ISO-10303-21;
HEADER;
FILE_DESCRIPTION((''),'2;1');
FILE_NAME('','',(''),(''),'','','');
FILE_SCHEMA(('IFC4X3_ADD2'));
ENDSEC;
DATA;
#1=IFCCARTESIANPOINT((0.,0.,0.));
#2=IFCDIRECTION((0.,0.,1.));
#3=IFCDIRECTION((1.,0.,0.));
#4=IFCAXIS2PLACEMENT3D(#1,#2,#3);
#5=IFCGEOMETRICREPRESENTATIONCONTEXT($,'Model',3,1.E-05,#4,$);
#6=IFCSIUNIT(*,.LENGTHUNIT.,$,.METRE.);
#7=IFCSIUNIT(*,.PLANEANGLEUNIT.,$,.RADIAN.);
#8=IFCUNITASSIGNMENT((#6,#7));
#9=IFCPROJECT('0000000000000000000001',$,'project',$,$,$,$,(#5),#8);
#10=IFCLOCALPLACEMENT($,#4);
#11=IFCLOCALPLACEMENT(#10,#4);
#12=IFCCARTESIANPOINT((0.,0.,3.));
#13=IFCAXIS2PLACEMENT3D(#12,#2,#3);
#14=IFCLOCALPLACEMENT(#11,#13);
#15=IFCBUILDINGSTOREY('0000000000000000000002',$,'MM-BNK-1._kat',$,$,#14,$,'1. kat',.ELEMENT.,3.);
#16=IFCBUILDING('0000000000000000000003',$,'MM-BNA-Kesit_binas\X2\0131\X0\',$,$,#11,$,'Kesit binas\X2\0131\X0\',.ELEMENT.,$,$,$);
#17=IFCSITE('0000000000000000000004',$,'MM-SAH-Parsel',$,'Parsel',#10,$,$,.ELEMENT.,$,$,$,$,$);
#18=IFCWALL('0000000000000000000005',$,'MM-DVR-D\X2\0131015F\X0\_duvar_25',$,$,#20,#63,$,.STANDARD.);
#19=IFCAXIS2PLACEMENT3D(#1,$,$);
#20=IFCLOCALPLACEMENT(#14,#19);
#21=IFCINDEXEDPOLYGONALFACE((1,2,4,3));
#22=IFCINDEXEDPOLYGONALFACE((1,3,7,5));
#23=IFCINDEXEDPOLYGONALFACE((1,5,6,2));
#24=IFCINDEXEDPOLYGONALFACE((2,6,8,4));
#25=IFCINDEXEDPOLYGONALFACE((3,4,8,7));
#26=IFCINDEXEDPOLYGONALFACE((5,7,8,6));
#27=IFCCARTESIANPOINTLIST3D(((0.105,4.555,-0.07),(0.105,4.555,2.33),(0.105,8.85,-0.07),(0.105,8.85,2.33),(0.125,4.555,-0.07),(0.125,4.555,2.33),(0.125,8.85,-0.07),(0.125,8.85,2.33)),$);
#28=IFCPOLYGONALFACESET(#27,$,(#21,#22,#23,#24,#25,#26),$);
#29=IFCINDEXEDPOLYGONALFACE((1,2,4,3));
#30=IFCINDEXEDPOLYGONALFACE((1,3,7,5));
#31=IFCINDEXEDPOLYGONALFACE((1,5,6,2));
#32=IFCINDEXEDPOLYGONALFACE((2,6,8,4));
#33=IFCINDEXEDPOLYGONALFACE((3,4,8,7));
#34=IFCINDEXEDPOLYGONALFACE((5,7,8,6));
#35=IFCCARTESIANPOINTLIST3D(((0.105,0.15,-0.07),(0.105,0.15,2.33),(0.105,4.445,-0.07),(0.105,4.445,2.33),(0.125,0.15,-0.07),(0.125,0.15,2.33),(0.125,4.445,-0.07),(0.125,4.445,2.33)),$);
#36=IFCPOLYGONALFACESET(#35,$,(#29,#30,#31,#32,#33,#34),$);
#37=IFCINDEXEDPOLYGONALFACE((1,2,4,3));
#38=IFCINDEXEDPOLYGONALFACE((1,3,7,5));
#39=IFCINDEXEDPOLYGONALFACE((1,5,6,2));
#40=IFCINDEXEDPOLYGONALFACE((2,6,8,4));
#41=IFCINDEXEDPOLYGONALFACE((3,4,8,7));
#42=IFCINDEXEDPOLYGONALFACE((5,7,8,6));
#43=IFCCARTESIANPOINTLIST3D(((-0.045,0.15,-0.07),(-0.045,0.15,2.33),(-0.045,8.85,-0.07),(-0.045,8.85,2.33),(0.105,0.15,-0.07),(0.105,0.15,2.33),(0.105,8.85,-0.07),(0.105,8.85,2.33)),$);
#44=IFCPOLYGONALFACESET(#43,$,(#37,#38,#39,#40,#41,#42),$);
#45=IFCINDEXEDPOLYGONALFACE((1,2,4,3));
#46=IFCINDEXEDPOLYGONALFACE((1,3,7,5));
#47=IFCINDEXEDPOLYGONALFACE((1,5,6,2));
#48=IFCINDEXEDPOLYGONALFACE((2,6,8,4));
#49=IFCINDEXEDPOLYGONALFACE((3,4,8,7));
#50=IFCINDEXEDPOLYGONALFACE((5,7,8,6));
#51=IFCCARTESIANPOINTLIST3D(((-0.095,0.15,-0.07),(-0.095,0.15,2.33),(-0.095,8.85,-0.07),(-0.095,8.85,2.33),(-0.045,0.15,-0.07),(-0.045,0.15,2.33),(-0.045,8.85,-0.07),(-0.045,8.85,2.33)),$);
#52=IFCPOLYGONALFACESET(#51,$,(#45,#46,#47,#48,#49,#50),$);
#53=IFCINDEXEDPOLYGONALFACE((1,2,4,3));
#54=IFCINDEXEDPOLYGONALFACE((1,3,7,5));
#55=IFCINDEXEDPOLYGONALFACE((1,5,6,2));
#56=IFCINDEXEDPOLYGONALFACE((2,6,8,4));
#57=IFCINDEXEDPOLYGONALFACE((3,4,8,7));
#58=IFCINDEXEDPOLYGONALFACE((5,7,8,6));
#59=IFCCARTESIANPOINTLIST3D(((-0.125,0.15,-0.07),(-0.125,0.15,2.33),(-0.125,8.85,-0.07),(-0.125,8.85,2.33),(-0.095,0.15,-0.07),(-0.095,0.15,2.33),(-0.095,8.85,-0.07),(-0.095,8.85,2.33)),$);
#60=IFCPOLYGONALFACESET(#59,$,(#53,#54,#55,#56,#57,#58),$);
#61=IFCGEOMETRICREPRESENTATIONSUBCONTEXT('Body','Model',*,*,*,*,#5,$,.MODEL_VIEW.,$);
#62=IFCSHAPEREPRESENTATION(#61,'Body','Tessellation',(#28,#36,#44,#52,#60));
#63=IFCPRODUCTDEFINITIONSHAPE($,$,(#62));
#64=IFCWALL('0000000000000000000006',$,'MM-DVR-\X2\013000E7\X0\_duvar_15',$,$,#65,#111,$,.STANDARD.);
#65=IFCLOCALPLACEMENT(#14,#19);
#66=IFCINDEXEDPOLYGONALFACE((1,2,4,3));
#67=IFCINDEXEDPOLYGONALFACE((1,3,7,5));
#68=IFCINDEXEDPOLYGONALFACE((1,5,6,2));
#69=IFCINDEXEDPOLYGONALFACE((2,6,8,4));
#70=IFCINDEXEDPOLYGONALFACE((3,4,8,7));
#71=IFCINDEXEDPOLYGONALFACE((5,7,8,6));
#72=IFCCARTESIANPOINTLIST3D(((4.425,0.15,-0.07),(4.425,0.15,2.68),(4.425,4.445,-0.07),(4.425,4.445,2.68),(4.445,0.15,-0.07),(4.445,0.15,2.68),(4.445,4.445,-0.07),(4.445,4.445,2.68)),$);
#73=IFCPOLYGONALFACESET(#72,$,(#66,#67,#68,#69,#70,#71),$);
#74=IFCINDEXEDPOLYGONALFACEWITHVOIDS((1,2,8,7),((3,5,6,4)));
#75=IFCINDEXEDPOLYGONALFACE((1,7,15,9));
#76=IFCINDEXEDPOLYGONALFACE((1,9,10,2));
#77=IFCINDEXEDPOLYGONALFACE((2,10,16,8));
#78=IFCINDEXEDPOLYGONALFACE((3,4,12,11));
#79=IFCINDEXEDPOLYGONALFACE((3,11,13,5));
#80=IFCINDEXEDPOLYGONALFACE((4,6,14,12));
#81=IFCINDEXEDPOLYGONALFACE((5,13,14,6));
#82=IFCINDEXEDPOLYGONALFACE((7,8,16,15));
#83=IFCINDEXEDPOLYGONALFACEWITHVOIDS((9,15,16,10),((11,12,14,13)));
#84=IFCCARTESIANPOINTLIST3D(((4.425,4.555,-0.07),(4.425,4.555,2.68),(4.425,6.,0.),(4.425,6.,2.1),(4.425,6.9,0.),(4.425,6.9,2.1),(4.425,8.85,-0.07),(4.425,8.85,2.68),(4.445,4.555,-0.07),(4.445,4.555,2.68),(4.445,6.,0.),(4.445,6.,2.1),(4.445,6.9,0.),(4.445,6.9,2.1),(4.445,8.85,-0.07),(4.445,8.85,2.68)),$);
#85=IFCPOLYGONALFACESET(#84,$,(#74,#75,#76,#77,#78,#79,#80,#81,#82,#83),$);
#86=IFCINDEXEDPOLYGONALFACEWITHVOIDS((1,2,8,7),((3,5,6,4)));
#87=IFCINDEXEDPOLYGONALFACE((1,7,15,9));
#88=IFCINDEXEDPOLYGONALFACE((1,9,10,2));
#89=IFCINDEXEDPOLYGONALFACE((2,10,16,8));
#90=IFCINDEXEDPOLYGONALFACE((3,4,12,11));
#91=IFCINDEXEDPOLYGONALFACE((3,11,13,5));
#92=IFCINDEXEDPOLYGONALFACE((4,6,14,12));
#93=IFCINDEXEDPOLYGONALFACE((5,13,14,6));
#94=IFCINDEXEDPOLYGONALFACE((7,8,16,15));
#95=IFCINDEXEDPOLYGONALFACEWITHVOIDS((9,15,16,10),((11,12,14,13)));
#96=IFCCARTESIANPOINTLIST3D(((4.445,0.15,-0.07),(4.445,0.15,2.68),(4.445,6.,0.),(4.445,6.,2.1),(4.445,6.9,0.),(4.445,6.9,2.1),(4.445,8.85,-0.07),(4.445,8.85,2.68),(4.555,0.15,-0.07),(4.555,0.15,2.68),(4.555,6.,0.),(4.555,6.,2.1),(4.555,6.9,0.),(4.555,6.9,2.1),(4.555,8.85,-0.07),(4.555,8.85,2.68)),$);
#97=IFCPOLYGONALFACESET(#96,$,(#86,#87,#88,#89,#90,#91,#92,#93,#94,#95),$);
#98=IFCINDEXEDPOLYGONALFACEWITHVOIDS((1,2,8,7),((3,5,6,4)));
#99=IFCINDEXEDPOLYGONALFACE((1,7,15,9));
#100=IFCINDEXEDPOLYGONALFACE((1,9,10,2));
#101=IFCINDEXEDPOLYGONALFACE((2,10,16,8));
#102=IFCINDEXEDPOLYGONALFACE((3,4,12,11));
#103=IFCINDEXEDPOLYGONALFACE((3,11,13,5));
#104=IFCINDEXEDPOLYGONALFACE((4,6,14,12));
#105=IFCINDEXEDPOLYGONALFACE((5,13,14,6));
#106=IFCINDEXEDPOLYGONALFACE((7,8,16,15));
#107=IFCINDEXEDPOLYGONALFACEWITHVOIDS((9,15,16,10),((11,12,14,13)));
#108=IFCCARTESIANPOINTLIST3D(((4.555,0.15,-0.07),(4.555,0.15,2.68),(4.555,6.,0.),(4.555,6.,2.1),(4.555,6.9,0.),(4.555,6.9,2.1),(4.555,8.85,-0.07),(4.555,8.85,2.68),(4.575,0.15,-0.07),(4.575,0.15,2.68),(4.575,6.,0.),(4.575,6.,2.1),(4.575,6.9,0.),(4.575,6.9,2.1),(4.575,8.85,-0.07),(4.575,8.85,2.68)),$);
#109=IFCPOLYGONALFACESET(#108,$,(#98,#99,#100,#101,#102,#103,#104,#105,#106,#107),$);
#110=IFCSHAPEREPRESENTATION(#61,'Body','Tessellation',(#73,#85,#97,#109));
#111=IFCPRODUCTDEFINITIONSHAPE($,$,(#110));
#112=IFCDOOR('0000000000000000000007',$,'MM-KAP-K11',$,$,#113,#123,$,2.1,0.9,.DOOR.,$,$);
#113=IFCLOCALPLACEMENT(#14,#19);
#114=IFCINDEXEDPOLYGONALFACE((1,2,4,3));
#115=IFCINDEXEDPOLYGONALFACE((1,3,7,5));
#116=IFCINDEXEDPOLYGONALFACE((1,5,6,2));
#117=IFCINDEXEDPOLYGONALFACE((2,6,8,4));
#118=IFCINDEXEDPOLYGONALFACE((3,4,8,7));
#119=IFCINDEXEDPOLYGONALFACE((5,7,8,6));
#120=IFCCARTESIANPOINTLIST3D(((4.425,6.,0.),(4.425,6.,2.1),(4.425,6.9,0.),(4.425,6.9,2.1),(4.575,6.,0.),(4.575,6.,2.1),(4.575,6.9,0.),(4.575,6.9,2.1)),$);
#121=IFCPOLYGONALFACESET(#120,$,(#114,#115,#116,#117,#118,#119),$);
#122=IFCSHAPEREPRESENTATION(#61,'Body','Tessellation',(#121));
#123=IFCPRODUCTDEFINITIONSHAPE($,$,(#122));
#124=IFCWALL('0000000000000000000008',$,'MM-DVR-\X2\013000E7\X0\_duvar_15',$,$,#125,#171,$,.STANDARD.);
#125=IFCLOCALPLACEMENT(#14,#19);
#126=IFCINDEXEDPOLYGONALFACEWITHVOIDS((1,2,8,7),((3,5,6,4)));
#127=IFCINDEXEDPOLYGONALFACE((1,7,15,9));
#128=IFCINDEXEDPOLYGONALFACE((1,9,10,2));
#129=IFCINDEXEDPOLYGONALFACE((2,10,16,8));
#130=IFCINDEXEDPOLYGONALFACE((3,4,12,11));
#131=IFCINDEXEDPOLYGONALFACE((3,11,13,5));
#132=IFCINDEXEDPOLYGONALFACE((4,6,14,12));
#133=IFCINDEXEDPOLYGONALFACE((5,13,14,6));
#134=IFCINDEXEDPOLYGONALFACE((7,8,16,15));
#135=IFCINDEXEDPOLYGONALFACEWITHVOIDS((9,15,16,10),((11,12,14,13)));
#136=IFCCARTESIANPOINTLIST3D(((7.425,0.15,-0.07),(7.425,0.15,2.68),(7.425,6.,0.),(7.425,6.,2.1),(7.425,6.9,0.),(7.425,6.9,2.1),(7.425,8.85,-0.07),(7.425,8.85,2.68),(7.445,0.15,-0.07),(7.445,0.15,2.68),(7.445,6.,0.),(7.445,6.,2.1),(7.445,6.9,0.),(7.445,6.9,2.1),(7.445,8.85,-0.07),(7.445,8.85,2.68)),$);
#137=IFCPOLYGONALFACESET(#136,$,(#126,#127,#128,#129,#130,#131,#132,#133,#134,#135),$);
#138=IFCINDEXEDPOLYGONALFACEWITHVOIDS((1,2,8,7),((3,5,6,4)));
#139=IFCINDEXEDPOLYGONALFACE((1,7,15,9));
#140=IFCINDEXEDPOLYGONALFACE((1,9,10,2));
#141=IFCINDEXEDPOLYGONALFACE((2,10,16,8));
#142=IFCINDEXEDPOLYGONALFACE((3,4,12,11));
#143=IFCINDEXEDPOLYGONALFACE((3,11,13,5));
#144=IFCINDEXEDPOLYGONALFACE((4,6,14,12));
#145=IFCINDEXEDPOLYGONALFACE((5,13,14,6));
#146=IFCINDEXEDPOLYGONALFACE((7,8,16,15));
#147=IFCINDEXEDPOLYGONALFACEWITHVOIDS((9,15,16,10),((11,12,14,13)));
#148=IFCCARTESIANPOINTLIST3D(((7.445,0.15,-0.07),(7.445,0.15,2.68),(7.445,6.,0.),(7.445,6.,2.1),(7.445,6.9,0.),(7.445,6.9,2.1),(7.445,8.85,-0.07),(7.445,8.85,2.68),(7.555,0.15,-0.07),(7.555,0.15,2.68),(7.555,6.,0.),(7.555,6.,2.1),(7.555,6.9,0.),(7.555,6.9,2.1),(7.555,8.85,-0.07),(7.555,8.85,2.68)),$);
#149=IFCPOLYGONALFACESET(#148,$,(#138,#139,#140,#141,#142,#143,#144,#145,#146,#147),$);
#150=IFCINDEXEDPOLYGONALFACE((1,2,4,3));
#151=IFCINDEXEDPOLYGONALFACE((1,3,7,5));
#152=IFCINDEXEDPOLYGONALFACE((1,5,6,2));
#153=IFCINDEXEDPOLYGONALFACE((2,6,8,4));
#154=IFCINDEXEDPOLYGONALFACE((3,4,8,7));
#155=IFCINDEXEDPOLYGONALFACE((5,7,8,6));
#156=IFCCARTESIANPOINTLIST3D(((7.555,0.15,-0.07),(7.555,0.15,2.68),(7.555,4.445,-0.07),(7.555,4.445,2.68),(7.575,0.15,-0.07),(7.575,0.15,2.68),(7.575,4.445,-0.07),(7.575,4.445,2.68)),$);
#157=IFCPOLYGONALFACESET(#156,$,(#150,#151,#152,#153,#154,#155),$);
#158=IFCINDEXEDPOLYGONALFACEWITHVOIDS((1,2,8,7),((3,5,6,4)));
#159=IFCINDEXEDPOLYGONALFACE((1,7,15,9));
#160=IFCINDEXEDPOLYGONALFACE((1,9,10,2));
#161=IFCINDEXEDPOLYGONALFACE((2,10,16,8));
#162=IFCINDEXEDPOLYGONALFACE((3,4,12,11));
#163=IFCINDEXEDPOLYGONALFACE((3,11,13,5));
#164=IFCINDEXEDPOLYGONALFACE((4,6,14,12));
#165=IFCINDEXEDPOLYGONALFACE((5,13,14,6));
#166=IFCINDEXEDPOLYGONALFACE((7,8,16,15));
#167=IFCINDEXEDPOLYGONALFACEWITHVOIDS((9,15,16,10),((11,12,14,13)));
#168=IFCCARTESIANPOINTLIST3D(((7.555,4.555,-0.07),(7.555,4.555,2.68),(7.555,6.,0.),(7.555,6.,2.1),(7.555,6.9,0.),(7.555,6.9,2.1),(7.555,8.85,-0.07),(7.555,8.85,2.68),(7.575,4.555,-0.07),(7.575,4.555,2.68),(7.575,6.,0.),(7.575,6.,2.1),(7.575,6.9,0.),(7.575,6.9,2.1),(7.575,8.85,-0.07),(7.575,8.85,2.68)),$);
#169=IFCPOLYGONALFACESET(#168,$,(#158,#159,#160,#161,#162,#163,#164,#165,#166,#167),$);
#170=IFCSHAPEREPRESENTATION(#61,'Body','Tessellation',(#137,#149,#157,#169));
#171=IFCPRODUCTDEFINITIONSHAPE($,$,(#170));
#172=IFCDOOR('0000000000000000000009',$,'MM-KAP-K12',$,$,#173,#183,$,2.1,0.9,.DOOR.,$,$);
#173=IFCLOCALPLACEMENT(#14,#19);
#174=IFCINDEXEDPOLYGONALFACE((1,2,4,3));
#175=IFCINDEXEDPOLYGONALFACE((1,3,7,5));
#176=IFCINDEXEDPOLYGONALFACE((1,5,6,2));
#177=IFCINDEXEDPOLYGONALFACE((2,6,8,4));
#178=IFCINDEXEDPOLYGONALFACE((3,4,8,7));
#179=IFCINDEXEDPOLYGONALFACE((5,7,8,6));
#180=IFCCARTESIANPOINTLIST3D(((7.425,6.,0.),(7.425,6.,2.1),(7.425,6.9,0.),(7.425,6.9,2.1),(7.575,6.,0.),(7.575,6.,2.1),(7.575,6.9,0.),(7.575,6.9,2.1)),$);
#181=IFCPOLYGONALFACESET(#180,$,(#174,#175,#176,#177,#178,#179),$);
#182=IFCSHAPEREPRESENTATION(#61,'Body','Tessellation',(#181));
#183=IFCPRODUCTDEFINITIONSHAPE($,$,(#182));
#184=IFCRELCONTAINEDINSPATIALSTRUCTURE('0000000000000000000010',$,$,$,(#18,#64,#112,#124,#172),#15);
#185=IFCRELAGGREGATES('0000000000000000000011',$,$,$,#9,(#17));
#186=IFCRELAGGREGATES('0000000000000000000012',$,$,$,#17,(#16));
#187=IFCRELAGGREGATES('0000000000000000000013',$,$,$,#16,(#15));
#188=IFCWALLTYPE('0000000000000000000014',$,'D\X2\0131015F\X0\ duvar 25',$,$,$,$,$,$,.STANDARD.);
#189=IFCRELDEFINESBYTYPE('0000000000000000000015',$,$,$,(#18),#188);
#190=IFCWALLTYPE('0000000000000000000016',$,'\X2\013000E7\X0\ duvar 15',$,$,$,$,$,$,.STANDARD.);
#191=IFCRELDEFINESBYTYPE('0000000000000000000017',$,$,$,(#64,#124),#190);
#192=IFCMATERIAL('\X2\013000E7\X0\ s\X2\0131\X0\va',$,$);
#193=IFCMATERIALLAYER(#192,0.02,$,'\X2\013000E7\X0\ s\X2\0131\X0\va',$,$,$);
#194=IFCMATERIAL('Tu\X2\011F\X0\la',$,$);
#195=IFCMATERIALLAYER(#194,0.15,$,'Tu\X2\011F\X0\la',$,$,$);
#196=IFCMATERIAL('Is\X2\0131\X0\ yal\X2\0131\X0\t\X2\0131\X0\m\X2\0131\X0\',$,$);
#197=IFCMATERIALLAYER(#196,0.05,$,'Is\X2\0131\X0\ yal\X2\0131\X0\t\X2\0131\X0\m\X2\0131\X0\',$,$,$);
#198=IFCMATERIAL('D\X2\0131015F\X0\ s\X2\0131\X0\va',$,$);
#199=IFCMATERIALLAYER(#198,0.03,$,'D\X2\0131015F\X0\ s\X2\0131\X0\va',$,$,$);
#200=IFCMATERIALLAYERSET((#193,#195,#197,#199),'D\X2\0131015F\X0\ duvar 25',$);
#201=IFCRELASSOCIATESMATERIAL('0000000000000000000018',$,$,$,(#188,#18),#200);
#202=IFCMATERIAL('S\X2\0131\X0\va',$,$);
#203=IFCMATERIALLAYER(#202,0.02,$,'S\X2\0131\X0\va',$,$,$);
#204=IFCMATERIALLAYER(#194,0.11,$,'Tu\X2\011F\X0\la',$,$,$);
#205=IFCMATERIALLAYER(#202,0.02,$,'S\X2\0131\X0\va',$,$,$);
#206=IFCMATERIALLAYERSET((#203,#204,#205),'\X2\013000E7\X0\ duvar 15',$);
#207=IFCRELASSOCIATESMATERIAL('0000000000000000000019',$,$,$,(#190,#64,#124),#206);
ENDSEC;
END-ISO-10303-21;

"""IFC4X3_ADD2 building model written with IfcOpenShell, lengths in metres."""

from ifc_helpers import new_model, si_unit, frame, origin, origin_with_axes, place, context, subcontext, project, spatial, polyline, outline, extrude, material, layer, layer_set, type_object, element, fill, save


model = new_model("IFC4X3_ADD2")

# Units and contexts
model_context = context("Model", 3, precision=1e-05, world=origin_with_axes())
body_context = subcontext(model_context, "Body", "Model", "MODEL_VIEW")
ifc_project = project(units=[si_unit("LENGTHUNIT", "METRE"), si_unit("PLANEANGLEUNIT", "RADIAN")], contexts=[model_context])

# Site, building, storey
site_placement = place(None, origin_with_axes())
site = spatial("IfcSite", under=ifc_project, at=site_placement, Name="MM-SAH-Parsel", ObjectType="Parsel", CompositionType="ELEMENT")
building_placement = place(site_placement, origin_with_axes())
building = spatial("IfcBuilding", under=site, at=building_placement, Name="MM-BNA-Kesit_binası", LongName="Kesit binası", CompositionType="ELEMENT")
storey_placement = place(building_placement, frame((0.0, 0.0, 3.0), z_axis=(0.0, 0.0, 1.0), x_axis=(1.0, 0.0, 0.0)))
storey = spatial("IfcBuildingStorey", under=building, at=storey_placement, Name="MM-BNK-1._kat", LongName="1. kat", CompositionType="ELEMENT", Elevation=3.0)

# Shared definitions
ifc_material_1 = material(Name="İç sıva")
ifc_layer_1 = layer(ifc_material_1, 0.02, Name="İç sıva")
ifc_material_2 = material(Name="Tuğla")
ifc_layer_2 = layer(ifc_material_2, 0.15, Name="Tuğla")
ifc_material_3 = material(Name="Isı yalıtımı")
ifc_layer_3 = layer(ifc_material_3, 0.05, Name="Isı yalıtımı")
ifc_material_4 = material(Name="Dış sıva")
ifc_layer_4 = layer(ifc_material_4, 0.03, Name="Dış sıva")
ifc_layer_set_1 = layer_set([ifc_layer_1, ifc_layer_2, ifc_layer_3, ifc_layer_4], Name="Dış duvar 25")
wall_type_1 = type_object("IfcWallType", Name="Dış duvar 25", PredefinedType="STANDARD", material=ifc_layer_set_1)

# Wall
wall_1_placement = place(storey_placement, origin_with_axes())
element("IfcWall", 1, at=wall_1_placement, inside=storey, type_object=wall_type_1, material=ifc_layer_set_1, Name="MM-DVR-Dış_duvar_25", PredefinedType="STANDARD", context=body_context, shape_type="SweptSolid", body=[
    extrude(outline(polyline([(0.105, 8.85), (0.105, 4.555), (0.125, 4.555), (0.125, 8.85), (0.105, 8.85)])), frame((0.0, 0.0, -0.07)), (0.0, 0.0, 1.0), 2.4),
    extrude(outline(polyline([(0.105, 4.445), (0.105, 0.15), (0.125, 0.15), (0.125, 4.445), (0.105, 4.445)])), frame((0.0, 0.0, -0.07)), (0.0, 0.0, 1.0), 2.4),
    extrude(outline(polyline([(-0.045, 8.85), (-0.045, 0.15), (0.105, 0.15), (0.105, 8.85), (-0.045, 8.85)])), frame((0.0, 0.0, -0.07)), (0.0, 0.0, 1.0), 2.4),
    extrude(outline(polyline([(-0.095, 8.85), (-0.095, 0.15), (-0.045, 0.15), (-0.045, 8.85), (-0.095, 8.85)])), frame((0.0, 0.0, -0.07)), (0.0, 0.0, 1.0), 2.4),
    extrude(outline(polyline([(-0.125, 8.85), (-0.125, 0.15), (-0.095, 0.15), (-0.095, 8.85), (-0.125, 8.85)])), frame((0.0, 0.0, -0.07)), (0.0, 0.0, 1.0), 2.4),
])

# Walls, openings, doors
ifc_material_5 = material(Name="Sıva")
ifc_layer_5 = layer(ifc_material_5, 0.02, Name="Sıva")
ifc_layer_6 = layer(ifc_material_2, 0.11, Name="Tuğla")
ifc_layer_7 = layer(ifc_material_5, 0.02, Name="Sıva")
ifc_layer_set_2 = layer_set([ifc_layer_5, ifc_layer_6, ifc_layer_7], Name="İç duvar 15")
wall_type_2 = type_object("IfcWallType", Name="İç duvar 15", PredefinedType="STANDARD", material=ifc_layer_set_2)
wall_2_placement = place(storey_placement, origin_with_axes())
wall_2 = element("IfcWall", 2, at=wall_2_placement, inside=storey, type_object=wall_type_2, material=ifc_layer_set_2, Name="MM-DVR-İç_duvar_15", PredefinedType="STANDARD", context=body_context, shape_type="SweptSolid", body=[
    extrude(outline(polyline([(4.445, 0.15), (4.445, 4.445), (4.425, 4.445), (4.425, 0.15), (4.445, 0.15)])), frame((0.0, 0.0, -0.07)), (0.0, 0.0, 1.0), 2.75),
    extrude(outline(polyline([(4.445, 4.555), (4.445, 8.85), (4.425, 8.85), (4.425, 4.555), (4.445, 4.555)])), frame((0.0, 0.0, -0.07)), (0.0, 0.0, 1.0), 2.75),
    extrude(outline(polyline([(4.555, 0.15), (4.555, 8.85), (4.445, 8.85), (4.445, 0.15), (4.555, 0.15)])), frame((0.0, 0.0, -0.07)), (0.0, 0.0, 1.0), 2.75),
    extrude(outline(polyline([(4.575, 0.15), (4.575, 8.85), (4.555, 8.85), (4.555, 0.15), (4.575, 0.15)])), frame((0.0, 0.0, -0.07)), (0.0, 0.0, 1.0), 2.75),
])
opening_1_placement = place(storey_placement, origin_with_axes())
opening_1 = element("IfcOpeningElement", 3, at=opening_1_placement, cuts=wall_2, PredefinedType="OPENING", context=body_context, shape_type="SweptSolid", body=[
    extrude(outline(polyline([(4.425, 6.0), (4.425, 6.9), (4.575, 6.9), (4.575, 6.0), (4.425, 6.0)])), origin(), (0.0, 0.0, 1.0), 2.1),
])
door_1_placement = place(storey_placement, origin_with_axes())
door_1 = element("IfcDoor", 4, at=door_1_placement, inside=storey, Name="MM-KAP-K11", OverallHeight=2.1, OverallWidth=0.9, PredefinedType="DOOR", context=body_context, shape_type="SweptSolid", body=[
    extrude(outline(polyline([(4.425, 6.0), (4.425, 6.9), (4.575, 6.9), (4.575, 6.0), (4.425, 6.0)])), origin(), (0.0, 0.0, 1.0), 2.1),
])
fill(opening_1, door_1)
wall_3_placement = place(storey_placement, origin_with_axes())
wall_3 = element("IfcWall", 5, at=wall_3_placement, inside=storey, type_object=wall_type_2, material=ifc_layer_set_2, Name="MM-DVR-İç_duvar_15", PredefinedType="STANDARD", context=body_context, shape_type="SweptSolid", body=[
    extrude(outline(polyline([(7.445, 0.15), (7.445, 8.85), (7.425, 8.85), (7.425, 0.15), (7.445, 0.15)])), frame((0.0, 0.0, -0.07)), (0.0, 0.0, 1.0), 2.75),
    extrude(outline(polyline([(7.555, 0.15), (7.555, 8.85), (7.445, 8.85), (7.445, 0.15), (7.555, 0.15)])), frame((0.0, 0.0, -0.07)), (0.0, 0.0, 1.0), 2.75),
    extrude(outline(polyline([(7.575, 0.15), (7.575, 4.445), (7.555, 4.445), (7.555, 0.15), (7.575, 0.15)])), frame((0.0, 0.0, -0.07)), (0.0, 0.0, 1.0), 2.75),
    extrude(outline(polyline([(7.575, 4.555), (7.575, 8.85), (7.555, 8.85), (7.555, 4.555), (7.575, 4.555)])), frame((0.0, 0.0, -0.07)), (0.0, 0.0, 1.0), 2.75),
])
opening_2_placement = place(storey_placement, origin_with_axes())
opening_2 = element("IfcOpeningElement", 6, at=opening_2_placement, cuts=wall_3, PredefinedType="OPENING", context=body_context, shape_type="SweptSolid", body=[
    extrude(outline(polyline([(7.425, 6.0), (7.425, 6.9), (7.575, 6.9), (7.575, 6.0), (7.425, 6.0)])), origin(), (0.0, 0.0, 1.0), 2.1),
])
door_2_placement = place(storey_placement, origin_with_axes())
door_2 = element("IfcDoor", 7, at=door_2_placement, inside=storey, Name="MM-KAP-K12", OverallHeight=2.1, OverallWidth=0.9, PredefinedType="DOOR", context=body_context, shape_type="SweptSolid", body=[
    extrude(outline(polyline([(7.425, 6.0), (7.425, 6.9), (7.575, 6.9), (7.575, 6.0), (7.425, 6.0)])), origin(), (0.0, 0.0, 1.0), 2.1),
])
fill(opening_2, door_2)

save(model, "model.ifc")
